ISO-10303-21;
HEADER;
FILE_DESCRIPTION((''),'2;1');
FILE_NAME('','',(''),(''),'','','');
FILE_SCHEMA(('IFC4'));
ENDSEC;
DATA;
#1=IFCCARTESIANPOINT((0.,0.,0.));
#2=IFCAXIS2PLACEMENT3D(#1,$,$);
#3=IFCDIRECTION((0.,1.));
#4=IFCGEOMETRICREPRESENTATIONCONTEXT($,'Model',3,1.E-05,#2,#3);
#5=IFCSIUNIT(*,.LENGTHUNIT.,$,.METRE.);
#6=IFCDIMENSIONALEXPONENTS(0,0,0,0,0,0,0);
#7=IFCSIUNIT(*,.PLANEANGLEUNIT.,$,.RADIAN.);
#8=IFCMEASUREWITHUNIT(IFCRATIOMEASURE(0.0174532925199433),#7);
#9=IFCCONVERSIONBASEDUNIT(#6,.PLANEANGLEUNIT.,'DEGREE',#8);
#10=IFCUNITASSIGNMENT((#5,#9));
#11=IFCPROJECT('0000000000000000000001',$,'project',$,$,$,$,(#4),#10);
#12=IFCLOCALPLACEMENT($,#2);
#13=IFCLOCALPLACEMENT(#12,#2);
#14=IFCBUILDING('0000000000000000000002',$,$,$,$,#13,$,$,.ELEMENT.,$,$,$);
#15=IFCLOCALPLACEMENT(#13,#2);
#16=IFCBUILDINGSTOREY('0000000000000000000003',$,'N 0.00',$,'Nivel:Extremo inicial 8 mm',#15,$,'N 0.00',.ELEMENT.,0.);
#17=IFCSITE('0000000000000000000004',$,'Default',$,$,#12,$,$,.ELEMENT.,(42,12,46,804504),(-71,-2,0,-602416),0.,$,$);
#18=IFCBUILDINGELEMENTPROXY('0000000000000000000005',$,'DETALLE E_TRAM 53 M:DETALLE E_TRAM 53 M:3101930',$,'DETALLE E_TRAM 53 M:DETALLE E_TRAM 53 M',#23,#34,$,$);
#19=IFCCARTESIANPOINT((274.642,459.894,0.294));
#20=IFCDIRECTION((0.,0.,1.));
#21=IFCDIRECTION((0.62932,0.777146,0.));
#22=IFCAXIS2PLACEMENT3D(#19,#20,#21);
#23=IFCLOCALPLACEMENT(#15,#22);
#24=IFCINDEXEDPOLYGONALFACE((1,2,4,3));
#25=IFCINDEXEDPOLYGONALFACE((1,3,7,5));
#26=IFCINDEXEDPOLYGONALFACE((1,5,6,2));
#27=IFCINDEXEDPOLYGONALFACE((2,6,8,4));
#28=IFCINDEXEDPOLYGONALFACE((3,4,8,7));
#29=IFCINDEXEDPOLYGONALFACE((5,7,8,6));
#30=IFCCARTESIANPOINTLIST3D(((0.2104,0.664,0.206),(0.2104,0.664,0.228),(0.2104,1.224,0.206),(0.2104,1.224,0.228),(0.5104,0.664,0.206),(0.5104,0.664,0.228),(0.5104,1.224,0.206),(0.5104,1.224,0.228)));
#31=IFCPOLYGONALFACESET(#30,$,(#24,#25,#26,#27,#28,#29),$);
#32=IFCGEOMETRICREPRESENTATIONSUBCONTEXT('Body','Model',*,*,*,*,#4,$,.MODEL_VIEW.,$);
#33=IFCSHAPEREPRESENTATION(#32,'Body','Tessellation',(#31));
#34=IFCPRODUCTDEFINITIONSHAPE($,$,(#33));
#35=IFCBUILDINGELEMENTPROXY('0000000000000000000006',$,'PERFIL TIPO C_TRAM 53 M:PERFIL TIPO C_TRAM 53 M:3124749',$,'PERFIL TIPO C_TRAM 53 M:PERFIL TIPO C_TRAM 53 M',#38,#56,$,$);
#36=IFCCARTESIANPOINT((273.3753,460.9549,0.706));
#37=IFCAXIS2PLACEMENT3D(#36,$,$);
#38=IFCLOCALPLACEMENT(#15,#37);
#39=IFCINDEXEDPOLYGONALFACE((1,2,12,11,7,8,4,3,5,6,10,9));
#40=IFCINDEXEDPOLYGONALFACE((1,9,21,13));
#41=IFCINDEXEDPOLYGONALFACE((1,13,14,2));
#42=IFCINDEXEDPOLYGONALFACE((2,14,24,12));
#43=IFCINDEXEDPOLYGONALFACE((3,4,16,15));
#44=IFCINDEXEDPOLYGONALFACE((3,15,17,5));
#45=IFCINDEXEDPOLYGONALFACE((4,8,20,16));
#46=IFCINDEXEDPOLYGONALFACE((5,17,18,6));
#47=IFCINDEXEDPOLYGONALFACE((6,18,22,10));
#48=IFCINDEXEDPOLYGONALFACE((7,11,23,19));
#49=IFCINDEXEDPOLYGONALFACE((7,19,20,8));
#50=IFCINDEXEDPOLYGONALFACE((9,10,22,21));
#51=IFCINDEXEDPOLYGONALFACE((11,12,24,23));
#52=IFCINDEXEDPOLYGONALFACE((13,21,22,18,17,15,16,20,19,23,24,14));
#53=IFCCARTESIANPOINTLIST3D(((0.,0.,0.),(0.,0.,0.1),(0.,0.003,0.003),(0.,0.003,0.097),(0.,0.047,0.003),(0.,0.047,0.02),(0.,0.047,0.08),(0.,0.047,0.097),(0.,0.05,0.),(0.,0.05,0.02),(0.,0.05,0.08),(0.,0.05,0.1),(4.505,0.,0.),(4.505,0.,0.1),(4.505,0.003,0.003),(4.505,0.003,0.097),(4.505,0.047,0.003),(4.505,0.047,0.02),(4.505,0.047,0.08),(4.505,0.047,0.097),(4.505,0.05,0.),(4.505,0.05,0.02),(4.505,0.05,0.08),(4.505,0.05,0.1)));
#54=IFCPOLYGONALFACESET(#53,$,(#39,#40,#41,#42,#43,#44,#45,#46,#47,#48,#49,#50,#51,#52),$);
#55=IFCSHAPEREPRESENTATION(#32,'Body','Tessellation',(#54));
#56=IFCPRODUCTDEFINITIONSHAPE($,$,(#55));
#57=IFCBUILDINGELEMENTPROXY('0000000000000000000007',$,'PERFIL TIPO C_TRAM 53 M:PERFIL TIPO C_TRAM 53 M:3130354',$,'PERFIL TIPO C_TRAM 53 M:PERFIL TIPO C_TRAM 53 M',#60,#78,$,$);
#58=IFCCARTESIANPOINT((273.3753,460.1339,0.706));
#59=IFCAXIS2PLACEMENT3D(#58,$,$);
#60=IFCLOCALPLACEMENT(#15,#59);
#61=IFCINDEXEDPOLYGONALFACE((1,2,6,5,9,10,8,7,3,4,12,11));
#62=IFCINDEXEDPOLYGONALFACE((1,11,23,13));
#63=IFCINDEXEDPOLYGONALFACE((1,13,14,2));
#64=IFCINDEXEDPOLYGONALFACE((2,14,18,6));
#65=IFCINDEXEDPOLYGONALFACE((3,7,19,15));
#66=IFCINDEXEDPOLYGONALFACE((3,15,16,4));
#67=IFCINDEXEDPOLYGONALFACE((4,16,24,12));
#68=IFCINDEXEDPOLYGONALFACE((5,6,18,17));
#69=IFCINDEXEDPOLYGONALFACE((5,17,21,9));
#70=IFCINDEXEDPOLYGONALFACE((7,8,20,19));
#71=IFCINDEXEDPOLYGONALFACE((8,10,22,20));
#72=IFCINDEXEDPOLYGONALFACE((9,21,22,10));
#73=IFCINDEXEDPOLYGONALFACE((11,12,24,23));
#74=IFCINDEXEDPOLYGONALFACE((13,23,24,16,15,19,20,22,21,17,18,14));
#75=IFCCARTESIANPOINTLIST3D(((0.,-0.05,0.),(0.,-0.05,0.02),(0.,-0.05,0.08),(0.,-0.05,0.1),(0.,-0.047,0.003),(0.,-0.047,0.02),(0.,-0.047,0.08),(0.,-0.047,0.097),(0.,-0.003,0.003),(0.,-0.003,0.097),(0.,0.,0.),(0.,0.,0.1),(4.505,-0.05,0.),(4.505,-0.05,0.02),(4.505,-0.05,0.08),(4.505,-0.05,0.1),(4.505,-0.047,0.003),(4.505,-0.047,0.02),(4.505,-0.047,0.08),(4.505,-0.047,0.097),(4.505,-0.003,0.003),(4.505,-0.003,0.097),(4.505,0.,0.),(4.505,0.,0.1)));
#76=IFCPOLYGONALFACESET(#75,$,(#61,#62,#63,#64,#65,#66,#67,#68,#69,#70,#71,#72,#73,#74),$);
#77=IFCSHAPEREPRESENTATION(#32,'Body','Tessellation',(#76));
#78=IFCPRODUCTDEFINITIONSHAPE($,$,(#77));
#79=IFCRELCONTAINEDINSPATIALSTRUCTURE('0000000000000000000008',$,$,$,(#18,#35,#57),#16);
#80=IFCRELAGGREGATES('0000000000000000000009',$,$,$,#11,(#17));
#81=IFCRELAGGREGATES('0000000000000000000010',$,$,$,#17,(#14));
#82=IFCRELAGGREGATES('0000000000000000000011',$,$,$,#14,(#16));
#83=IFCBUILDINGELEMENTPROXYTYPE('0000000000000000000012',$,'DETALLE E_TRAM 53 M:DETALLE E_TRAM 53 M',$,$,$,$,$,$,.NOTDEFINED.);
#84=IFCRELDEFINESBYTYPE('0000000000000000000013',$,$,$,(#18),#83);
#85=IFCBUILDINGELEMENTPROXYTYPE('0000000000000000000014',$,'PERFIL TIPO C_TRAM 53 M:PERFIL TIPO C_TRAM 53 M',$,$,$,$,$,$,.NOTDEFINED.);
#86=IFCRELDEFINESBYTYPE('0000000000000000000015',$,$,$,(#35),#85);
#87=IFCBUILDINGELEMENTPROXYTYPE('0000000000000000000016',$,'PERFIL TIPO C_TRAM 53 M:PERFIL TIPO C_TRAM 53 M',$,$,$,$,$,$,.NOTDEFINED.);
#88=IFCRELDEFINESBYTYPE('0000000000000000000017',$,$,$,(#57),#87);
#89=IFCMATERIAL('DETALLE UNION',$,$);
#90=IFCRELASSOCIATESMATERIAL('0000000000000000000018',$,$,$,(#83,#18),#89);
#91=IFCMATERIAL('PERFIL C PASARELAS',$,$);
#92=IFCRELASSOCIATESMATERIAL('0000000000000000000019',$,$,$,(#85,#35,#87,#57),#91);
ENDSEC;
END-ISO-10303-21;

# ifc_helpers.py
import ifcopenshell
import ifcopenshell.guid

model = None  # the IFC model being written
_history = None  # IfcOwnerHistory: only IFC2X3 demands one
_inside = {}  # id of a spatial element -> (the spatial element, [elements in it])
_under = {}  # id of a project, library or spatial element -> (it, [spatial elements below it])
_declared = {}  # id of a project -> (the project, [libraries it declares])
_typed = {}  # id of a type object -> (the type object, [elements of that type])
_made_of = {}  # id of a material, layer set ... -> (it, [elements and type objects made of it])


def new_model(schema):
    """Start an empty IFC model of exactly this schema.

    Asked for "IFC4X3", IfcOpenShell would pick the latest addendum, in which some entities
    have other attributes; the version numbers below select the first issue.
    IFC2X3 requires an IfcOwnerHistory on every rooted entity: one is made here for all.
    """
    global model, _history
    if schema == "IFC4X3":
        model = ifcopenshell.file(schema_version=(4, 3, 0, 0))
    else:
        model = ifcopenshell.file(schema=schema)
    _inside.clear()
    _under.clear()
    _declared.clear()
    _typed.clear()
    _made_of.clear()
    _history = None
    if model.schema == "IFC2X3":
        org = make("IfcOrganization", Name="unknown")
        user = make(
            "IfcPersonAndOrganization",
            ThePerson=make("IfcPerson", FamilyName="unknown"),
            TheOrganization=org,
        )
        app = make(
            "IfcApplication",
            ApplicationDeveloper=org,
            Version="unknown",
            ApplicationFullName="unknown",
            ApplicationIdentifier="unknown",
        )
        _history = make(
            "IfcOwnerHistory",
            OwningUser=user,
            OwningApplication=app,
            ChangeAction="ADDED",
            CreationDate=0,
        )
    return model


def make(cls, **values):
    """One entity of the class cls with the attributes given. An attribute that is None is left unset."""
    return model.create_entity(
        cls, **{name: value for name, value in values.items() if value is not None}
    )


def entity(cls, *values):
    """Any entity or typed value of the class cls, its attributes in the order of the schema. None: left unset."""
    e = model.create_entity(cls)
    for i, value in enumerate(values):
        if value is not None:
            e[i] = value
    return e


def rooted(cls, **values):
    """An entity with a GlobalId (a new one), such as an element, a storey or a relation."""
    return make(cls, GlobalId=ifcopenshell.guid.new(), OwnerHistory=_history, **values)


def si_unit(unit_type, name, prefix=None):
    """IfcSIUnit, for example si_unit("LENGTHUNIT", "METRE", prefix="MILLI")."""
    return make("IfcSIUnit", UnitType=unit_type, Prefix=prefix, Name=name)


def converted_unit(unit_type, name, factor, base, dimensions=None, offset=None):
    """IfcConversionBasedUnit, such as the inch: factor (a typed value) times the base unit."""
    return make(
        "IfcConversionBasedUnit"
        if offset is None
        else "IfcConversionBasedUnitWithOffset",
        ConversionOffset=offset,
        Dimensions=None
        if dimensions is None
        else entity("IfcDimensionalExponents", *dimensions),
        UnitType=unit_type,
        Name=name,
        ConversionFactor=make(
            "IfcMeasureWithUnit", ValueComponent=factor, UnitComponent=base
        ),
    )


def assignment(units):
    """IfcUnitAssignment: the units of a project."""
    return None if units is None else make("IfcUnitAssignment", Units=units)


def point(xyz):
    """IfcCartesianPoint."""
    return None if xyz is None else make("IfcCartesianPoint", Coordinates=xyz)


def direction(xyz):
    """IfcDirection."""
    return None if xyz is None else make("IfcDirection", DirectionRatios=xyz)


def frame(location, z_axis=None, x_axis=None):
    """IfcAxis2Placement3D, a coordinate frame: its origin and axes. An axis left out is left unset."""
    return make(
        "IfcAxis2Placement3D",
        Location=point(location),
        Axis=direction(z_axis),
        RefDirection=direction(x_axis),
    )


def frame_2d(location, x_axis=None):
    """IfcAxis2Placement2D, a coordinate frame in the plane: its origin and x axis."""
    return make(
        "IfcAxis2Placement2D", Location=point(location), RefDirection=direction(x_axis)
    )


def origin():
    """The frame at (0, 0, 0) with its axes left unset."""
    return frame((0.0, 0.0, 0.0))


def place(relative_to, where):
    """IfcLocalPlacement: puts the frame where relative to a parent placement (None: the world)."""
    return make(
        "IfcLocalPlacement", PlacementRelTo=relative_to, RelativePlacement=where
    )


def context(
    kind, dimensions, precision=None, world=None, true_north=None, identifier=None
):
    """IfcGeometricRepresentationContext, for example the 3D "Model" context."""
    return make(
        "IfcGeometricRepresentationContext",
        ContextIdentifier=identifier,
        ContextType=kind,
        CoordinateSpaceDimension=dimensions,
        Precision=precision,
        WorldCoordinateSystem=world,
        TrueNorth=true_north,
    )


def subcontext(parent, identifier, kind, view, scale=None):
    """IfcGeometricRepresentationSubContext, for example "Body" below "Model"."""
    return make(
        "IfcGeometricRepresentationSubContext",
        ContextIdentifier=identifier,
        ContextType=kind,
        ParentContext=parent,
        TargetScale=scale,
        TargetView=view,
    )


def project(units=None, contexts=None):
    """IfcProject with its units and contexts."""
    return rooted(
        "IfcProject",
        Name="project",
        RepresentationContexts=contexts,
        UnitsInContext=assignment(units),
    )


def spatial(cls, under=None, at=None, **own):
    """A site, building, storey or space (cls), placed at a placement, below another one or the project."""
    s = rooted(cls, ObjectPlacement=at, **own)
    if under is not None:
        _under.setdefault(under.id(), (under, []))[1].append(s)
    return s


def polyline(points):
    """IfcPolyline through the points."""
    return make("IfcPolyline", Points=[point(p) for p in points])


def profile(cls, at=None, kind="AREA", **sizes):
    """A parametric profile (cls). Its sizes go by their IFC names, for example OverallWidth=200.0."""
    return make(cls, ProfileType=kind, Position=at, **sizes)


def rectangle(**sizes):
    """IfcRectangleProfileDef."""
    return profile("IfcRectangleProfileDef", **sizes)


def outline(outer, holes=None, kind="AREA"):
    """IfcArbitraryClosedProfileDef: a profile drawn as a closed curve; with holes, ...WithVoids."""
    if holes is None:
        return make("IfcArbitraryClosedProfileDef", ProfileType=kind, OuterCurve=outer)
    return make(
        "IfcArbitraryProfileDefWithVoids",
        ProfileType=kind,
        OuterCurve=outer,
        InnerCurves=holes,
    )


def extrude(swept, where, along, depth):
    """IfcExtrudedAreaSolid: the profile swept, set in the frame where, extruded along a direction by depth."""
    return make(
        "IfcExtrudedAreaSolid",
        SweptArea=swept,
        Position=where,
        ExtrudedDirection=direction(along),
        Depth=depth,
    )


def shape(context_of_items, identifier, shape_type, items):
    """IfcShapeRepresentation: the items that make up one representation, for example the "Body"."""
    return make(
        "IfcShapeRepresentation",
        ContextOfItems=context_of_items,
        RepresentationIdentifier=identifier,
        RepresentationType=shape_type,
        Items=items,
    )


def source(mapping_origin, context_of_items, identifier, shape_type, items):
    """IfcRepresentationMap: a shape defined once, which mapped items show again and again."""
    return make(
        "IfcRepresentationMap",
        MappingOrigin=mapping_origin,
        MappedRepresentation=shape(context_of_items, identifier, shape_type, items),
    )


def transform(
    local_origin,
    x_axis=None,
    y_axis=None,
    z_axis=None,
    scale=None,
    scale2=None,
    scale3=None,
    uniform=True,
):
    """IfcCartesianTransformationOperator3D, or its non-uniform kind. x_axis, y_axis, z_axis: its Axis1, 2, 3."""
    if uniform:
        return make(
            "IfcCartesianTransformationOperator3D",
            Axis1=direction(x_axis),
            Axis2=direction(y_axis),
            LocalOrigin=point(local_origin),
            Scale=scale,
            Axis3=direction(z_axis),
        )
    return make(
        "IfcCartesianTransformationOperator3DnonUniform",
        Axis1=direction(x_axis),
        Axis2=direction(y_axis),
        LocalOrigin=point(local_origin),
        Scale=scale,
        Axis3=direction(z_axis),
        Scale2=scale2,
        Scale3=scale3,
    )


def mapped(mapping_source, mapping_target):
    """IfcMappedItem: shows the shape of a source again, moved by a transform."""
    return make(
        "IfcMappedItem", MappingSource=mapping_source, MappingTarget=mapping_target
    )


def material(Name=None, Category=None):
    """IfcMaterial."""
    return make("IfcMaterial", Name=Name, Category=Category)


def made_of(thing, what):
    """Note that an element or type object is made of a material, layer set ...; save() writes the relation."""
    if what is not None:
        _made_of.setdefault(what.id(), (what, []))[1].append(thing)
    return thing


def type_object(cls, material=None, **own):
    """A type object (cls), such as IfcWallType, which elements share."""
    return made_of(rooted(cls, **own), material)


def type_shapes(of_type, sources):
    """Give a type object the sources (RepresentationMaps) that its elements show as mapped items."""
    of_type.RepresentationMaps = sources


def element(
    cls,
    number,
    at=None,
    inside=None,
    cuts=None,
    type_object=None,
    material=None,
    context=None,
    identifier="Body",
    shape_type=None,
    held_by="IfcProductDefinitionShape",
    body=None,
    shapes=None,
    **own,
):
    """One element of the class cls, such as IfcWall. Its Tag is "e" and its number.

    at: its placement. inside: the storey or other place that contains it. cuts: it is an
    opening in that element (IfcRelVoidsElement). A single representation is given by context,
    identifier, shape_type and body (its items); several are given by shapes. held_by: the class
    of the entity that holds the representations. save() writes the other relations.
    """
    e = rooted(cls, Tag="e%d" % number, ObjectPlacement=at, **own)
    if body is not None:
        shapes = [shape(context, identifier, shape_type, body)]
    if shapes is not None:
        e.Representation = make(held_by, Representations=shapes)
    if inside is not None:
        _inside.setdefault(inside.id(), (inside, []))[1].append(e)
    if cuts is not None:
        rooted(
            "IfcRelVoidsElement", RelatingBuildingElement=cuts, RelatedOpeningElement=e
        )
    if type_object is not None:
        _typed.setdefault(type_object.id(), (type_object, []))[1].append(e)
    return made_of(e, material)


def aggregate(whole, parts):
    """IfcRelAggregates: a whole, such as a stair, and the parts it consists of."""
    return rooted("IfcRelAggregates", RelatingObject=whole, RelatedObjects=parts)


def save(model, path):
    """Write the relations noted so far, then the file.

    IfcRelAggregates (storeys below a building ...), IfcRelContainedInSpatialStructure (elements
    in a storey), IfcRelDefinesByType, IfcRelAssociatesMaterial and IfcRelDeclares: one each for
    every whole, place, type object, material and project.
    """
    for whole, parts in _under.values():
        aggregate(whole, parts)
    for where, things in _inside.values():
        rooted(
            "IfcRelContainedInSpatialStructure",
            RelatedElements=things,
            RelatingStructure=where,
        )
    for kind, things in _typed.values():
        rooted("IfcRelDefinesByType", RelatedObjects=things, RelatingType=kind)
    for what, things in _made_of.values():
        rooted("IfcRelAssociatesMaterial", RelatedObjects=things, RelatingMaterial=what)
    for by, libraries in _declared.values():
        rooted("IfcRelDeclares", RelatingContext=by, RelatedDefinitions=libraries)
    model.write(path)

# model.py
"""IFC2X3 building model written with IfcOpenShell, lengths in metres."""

from ifc_helpers import new_model, entity, si_unit, converted_unit, direction, frame, frame_2d, origin, place, context, subcontext, project, spatial, polyline, rectangle, outline, extrude, source, transform, mapped, material, type_object, type_shapes, element, save


model = new_model("IFC2X3")

# Units and contexts
model_context = context("Model", 3, precision=1e-05, world=origin(), true_north=direction((0.0, 1.0)))
body_context = subcontext(model_context, "Body", "Model", "MODEL_VIEW")
ifc_project = project(units=[si_unit("LENGTHUNIT", "METRE"), converted_unit("PLANEANGLEUNIT", "DEGREE", entity("IfcRatioMeasure", 0.0174532925199433), si_unit("PLANEANGLEUNIT", "RADIAN"), dimensions=[0, 0, 0, 0, 0, 0, 0])], contexts=[model_context])

# Site, building, storey
site_placement = place(None, origin())
site = spatial("IfcSite", under=ifc_project, at=site_placement, Name="Default", CompositionType="ELEMENT", RefLatitude=(42, 12, 46, 804504), RefLongitude=(-71, -2, 0, -602416), RefElevation=0.0)
building_placement = place(site_placement, origin())
building = spatial("IfcBuilding", under=site, at=building_placement, CompositionType="ELEMENT")
storey_placement = place(building_placement, origin())
storey = spatial("IfcBuildingStorey", under=building, at=storey_placement, Name="N 0.00", ObjectType="Nivel:Extremo inicial 8 mm", LongName="N 0.00", CompositionType="ELEMENT", Elevation=0.0)

# Building element proxies
ifc_material_1 = material(Name="DETALLE UNION")
building_element_proxy_type_1 = type_object("IfcBuildingElementProxyType", Name="DETALLE E_TRAM 53 M:DETALLE E_TRAM 53 M", PredefinedType="NOTDEFINED", material=ifc_material_1)
shared_shape_1 = source(origin(), body_context, "Body", "SweptSolid", [
    extrude(rectangle(XDim=0.56, YDim=0.3, at=frame_2d((0.0, 0.0), x_axis=(1.0, 0.0))), frame((0.3604, 0.944, 0.206), z_axis=(0.0, 0.0, 1.0), x_axis=(0.0, 1.0, 0.0)), (0.0, 0.0, 1.0), 0.022),
])
type_shapes(building_element_proxy_type_1, [shared_shape_1])
proxy_1_placement = place(storey_placement, frame((274.642, 459.894, 0.294), z_axis=(0.0, 0.0, 1.0), x_axis=(0.62932, 0.777146, 0.0)))
element("IfcBuildingElementProxy", 1, at=proxy_1_placement, inside=storey, type_object=building_element_proxy_type_1, material=ifc_material_1, Name="DETALLE E_TRAM 53 M:DETALLE E_TRAM 53 M:3101930", ObjectType="DETALLE E_TRAM 53 M:DETALLE E_TRAM 53 M", context=body_context, shape_type="MappedRepresentation", body=[
    mapped(shared_shape_1, transform((0.0, 0.0, 0.0), scale=1.0)),
])
ifc_material_2 = material(Name="PERFIL C PASARELAS")
building_element_proxy_type_2 = type_object("IfcBuildingElementProxyType", Name="PERFIL TIPO C_TRAM 53 M:PERFIL TIPO C_TRAM 53 M", PredefinedType="NOTDEFINED", material=ifc_material_2)
shared_shape_2 = source(origin(), body_context, "Body", "SweptSolid", [
    extrude(outline(polyline([(-0.0172, 0.03), (-0.0142, 0.03), (-0.0142, 0.047), (0.0298, 0.047), (0.0298, -0.047), (-0.0142, -0.047), (-0.0142, -0.03), (-0.0172, -0.03), (-0.0172, -0.05), (0.0328, -0.05), (0.0328, 0.05), (-0.0172, 0.05), (-0.0172, 0.03)])), frame((0.0, 0.0328, 0.05), z_axis=(1.0, 0.0, 0.0), x_axis=(0.0, -1.0, 0.0)), (0.0, 0.0, 1.0), 4.505),
])
type_shapes(building_element_proxy_type_2, [shared_shape_2])
proxy_2_placement = place(storey_placement, frame((273.3753, 460.9549, 0.706)))
element("IfcBuildingElementProxy", 2, at=proxy_2_placement, inside=storey, type_object=building_element_proxy_type_2, material=ifc_material_2, Name="PERFIL TIPO C_TRAM 53 M:PERFIL TIPO C_TRAM 53 M:3124749", ObjectType="PERFIL TIPO C_TRAM 53 M:PERFIL TIPO C_TRAM 53 M", context=body_context, shape_type="MappedRepresentation", body=[
    mapped(shared_shape_2, transform((0.0, 0.0, 0.0), scale=1.0)),
])
building_element_proxy_type_3 = type_object("IfcBuildingElementProxyType", Name="PERFIL TIPO C_TRAM 53 M:PERFIL TIPO C_TRAM 53 M", PredefinedType="NOTDEFINED", material=ifc_material_2)
shared_shape_3 = source(origin(), body_context, "Body", "SweptSolid", [
    extrude(outline(polyline([(0.03, -0.0172), (0.05, -0.0172), (0.05, 0.0328), (-0.05, 0.0328), (-0.05, -0.0172), (-0.03, -0.0172), (-0.03, -0.0142), (-0.047, -0.0142), (-0.047, 0.0298), (0.047, 0.0298), (0.047, -0.0142), (0.03, -0.0142), (0.03, -0.0172)])), frame((0.0, -0.0328, 0.05), z_axis=(1.0, 0.0, 0.0), x_axis=(0.0, 0.0, -1.0)), (0.0, 0.0, 1.0), 4.505),
])
type_shapes(building_element_proxy_type_3, [shared_shape_3])
proxy_3_placement = place(storey_placement, frame((273.3753, 460.1339, 0.706)))
element("IfcBuildingElementProxy", 3, at=proxy_3_placement, inside=storey, type_object=building_element_proxy_type_3, material=ifc_material_2, Name="PERFIL TIPO C_TRAM 53 M:PERFIL TIPO C_TRAM 53 M:3130354", ObjectType="PERFIL TIPO C_TRAM 53 M:PERFIL TIPO C_TRAM 53 M", context=body_context, shape_type="MappedRepresentation", body=[
    mapped(shared_shape_3, transform((0.0, 0.0, 0.0), scale=1.0)),
])

save(model, "model.ifc")
